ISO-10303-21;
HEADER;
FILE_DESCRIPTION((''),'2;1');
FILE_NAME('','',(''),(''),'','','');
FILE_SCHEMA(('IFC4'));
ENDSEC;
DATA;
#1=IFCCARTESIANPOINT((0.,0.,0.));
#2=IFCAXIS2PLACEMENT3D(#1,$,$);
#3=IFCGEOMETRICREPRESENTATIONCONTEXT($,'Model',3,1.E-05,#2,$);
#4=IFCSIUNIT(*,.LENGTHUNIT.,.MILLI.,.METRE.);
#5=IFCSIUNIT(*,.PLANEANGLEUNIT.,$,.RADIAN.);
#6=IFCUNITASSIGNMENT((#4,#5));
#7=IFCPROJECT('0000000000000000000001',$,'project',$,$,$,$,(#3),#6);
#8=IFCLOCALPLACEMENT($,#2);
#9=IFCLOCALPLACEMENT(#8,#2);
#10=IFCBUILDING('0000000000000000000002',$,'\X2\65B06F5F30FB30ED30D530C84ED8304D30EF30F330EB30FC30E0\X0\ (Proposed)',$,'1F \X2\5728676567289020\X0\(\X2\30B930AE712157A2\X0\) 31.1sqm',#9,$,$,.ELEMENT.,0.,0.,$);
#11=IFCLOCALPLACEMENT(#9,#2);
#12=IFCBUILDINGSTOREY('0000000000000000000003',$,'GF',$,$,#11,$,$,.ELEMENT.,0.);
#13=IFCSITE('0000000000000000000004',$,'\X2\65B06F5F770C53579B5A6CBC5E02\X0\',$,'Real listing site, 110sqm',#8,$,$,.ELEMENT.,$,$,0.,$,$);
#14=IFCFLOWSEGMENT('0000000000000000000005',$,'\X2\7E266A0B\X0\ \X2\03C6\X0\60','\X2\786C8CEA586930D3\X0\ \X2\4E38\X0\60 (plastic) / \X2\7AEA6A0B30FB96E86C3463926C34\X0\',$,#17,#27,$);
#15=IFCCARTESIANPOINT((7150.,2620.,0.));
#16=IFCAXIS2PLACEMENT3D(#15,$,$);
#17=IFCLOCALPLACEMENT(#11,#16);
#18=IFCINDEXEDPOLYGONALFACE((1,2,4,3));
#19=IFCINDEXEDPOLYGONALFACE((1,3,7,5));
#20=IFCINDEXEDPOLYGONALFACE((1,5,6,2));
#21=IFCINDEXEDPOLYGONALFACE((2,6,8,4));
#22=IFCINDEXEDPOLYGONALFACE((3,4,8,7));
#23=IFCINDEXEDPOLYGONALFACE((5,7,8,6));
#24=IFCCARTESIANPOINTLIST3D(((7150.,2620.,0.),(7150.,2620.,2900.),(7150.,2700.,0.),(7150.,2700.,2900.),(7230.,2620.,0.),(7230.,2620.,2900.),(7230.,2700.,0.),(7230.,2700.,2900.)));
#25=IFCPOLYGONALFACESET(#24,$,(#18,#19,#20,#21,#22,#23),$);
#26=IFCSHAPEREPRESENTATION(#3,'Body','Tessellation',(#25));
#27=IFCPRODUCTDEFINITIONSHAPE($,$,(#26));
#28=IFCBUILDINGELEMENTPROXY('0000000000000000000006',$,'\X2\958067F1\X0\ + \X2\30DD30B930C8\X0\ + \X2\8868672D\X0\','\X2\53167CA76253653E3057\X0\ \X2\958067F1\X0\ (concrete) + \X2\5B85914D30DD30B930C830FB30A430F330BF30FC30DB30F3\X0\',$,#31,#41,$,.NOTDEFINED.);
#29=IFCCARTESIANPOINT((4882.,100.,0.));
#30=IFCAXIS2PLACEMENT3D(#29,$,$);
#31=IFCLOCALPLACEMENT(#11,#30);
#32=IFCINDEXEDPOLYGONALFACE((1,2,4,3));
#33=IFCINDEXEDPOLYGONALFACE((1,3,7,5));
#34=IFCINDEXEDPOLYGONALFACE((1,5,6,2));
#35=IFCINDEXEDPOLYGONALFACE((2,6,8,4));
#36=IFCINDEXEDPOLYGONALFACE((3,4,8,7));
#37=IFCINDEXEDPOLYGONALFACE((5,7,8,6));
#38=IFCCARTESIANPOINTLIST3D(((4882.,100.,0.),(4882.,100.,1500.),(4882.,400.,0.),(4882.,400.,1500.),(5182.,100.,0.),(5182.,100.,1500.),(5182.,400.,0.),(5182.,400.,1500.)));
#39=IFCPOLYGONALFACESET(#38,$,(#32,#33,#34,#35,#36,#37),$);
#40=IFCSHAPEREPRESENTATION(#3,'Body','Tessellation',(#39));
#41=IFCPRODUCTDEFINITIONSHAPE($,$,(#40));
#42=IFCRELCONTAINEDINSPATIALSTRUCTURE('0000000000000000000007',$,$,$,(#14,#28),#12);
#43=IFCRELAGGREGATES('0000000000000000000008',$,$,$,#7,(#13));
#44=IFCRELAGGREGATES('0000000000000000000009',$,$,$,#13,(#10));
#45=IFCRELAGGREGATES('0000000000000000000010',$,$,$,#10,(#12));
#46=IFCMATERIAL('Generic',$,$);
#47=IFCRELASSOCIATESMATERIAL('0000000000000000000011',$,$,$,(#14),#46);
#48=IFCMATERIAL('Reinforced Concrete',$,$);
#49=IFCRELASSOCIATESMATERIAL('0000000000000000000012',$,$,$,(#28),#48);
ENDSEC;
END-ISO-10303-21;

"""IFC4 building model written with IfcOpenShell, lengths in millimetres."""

from ifc_helpers import new_model, si_unit, frame, frame_2d, origin, place, context, project, spatial, rectangle, extrude, material, element, save


model = new_model("IFC4")

# Units and contexts
model_context = context("Model", 3, precision=1e-05, world=origin())
ifc_project = project(units=[si_unit("LENGTHUNIT", "METRE", prefix="MILLI"), si_unit("PLANEANGLEUNIT", "RADIAN")], contexts=[model_context])

# Site, building, storey
site_placement = place(None, origin())
site = spatial("IfcSite", under=ifc_project, at=site_placement, Name="新潟県南魚沼市", ObjectType="Real listing site, 110sqm", CompositionType="ELEMENT", RefElevation=0.0)
building_placement = place(site_placement, origin())
building = spatial("IfcBuilding", under=site, at=building_placement, Name="新潟・ロフト付きワンルーム (Proposed)", ObjectType="1F 在来木造(スギ無垢) 31.1sqm", CompositionType="ELEMENT", ElevationOfRefHeight=0.0, ElevationOfTerrain=0.0)
storey_placement = place(building_placement, origin())
storey = spatial("IfcBuildingStorey", under=building, at=storey_placement, Name="GF", CompositionType="ELEMENT", Elevation=0.0)

# Shared definitions
ifc_material_1 = material(Name="Reinforced Concrete")

# Shared definitions
ifc_material_2 = material(Name="Generic")

# Flow segment
flow_segment_1_placement = place(storey_placement, frame((7150.0, 2620.0, 0.0)))
element("IfcFlowSegment", 1, at=flow_segment_1_placement, inside=storey, material=ifc_material_2, Name="縦樋 φ60", Description="硬質塩ビ 丸60 (plastic) / 竪樋・雨水排水", context=model_context, shape_type="SweptSolid", body=[
    extrude(rectangle(XDim=80.0, YDim=80.0, at=frame_2d((40.0, 40.0))), frame((7150.0, 2620.0, 0.0)), (0.0, 0.0, 1.0), 2900.0),
])

# Building element proxy
proxy_placement = place(storey_placement, frame((4882.0, 100.0, 0.0)))
element("IfcBuildingElementProxy", 2, at=proxy_placement, inside=storey, material=ifc_material_1, Name="門柱 + ポスト + 表札", Description="化粧打放し 門柱 (concrete) + 宅配ポスト・インターホン", PredefinedType="NOTDEFINED", context=model_context, shape_type="SweptSolid", body=[
    extrude(rectangle(XDim=300.0, YDim=300.0, at=frame_2d((150.0, 150.0))), frame((4882.0, 100.0, 0.0)), (0.0, 0.0, 1.0), 1500.0),
])

save(model, "model.ifc")
